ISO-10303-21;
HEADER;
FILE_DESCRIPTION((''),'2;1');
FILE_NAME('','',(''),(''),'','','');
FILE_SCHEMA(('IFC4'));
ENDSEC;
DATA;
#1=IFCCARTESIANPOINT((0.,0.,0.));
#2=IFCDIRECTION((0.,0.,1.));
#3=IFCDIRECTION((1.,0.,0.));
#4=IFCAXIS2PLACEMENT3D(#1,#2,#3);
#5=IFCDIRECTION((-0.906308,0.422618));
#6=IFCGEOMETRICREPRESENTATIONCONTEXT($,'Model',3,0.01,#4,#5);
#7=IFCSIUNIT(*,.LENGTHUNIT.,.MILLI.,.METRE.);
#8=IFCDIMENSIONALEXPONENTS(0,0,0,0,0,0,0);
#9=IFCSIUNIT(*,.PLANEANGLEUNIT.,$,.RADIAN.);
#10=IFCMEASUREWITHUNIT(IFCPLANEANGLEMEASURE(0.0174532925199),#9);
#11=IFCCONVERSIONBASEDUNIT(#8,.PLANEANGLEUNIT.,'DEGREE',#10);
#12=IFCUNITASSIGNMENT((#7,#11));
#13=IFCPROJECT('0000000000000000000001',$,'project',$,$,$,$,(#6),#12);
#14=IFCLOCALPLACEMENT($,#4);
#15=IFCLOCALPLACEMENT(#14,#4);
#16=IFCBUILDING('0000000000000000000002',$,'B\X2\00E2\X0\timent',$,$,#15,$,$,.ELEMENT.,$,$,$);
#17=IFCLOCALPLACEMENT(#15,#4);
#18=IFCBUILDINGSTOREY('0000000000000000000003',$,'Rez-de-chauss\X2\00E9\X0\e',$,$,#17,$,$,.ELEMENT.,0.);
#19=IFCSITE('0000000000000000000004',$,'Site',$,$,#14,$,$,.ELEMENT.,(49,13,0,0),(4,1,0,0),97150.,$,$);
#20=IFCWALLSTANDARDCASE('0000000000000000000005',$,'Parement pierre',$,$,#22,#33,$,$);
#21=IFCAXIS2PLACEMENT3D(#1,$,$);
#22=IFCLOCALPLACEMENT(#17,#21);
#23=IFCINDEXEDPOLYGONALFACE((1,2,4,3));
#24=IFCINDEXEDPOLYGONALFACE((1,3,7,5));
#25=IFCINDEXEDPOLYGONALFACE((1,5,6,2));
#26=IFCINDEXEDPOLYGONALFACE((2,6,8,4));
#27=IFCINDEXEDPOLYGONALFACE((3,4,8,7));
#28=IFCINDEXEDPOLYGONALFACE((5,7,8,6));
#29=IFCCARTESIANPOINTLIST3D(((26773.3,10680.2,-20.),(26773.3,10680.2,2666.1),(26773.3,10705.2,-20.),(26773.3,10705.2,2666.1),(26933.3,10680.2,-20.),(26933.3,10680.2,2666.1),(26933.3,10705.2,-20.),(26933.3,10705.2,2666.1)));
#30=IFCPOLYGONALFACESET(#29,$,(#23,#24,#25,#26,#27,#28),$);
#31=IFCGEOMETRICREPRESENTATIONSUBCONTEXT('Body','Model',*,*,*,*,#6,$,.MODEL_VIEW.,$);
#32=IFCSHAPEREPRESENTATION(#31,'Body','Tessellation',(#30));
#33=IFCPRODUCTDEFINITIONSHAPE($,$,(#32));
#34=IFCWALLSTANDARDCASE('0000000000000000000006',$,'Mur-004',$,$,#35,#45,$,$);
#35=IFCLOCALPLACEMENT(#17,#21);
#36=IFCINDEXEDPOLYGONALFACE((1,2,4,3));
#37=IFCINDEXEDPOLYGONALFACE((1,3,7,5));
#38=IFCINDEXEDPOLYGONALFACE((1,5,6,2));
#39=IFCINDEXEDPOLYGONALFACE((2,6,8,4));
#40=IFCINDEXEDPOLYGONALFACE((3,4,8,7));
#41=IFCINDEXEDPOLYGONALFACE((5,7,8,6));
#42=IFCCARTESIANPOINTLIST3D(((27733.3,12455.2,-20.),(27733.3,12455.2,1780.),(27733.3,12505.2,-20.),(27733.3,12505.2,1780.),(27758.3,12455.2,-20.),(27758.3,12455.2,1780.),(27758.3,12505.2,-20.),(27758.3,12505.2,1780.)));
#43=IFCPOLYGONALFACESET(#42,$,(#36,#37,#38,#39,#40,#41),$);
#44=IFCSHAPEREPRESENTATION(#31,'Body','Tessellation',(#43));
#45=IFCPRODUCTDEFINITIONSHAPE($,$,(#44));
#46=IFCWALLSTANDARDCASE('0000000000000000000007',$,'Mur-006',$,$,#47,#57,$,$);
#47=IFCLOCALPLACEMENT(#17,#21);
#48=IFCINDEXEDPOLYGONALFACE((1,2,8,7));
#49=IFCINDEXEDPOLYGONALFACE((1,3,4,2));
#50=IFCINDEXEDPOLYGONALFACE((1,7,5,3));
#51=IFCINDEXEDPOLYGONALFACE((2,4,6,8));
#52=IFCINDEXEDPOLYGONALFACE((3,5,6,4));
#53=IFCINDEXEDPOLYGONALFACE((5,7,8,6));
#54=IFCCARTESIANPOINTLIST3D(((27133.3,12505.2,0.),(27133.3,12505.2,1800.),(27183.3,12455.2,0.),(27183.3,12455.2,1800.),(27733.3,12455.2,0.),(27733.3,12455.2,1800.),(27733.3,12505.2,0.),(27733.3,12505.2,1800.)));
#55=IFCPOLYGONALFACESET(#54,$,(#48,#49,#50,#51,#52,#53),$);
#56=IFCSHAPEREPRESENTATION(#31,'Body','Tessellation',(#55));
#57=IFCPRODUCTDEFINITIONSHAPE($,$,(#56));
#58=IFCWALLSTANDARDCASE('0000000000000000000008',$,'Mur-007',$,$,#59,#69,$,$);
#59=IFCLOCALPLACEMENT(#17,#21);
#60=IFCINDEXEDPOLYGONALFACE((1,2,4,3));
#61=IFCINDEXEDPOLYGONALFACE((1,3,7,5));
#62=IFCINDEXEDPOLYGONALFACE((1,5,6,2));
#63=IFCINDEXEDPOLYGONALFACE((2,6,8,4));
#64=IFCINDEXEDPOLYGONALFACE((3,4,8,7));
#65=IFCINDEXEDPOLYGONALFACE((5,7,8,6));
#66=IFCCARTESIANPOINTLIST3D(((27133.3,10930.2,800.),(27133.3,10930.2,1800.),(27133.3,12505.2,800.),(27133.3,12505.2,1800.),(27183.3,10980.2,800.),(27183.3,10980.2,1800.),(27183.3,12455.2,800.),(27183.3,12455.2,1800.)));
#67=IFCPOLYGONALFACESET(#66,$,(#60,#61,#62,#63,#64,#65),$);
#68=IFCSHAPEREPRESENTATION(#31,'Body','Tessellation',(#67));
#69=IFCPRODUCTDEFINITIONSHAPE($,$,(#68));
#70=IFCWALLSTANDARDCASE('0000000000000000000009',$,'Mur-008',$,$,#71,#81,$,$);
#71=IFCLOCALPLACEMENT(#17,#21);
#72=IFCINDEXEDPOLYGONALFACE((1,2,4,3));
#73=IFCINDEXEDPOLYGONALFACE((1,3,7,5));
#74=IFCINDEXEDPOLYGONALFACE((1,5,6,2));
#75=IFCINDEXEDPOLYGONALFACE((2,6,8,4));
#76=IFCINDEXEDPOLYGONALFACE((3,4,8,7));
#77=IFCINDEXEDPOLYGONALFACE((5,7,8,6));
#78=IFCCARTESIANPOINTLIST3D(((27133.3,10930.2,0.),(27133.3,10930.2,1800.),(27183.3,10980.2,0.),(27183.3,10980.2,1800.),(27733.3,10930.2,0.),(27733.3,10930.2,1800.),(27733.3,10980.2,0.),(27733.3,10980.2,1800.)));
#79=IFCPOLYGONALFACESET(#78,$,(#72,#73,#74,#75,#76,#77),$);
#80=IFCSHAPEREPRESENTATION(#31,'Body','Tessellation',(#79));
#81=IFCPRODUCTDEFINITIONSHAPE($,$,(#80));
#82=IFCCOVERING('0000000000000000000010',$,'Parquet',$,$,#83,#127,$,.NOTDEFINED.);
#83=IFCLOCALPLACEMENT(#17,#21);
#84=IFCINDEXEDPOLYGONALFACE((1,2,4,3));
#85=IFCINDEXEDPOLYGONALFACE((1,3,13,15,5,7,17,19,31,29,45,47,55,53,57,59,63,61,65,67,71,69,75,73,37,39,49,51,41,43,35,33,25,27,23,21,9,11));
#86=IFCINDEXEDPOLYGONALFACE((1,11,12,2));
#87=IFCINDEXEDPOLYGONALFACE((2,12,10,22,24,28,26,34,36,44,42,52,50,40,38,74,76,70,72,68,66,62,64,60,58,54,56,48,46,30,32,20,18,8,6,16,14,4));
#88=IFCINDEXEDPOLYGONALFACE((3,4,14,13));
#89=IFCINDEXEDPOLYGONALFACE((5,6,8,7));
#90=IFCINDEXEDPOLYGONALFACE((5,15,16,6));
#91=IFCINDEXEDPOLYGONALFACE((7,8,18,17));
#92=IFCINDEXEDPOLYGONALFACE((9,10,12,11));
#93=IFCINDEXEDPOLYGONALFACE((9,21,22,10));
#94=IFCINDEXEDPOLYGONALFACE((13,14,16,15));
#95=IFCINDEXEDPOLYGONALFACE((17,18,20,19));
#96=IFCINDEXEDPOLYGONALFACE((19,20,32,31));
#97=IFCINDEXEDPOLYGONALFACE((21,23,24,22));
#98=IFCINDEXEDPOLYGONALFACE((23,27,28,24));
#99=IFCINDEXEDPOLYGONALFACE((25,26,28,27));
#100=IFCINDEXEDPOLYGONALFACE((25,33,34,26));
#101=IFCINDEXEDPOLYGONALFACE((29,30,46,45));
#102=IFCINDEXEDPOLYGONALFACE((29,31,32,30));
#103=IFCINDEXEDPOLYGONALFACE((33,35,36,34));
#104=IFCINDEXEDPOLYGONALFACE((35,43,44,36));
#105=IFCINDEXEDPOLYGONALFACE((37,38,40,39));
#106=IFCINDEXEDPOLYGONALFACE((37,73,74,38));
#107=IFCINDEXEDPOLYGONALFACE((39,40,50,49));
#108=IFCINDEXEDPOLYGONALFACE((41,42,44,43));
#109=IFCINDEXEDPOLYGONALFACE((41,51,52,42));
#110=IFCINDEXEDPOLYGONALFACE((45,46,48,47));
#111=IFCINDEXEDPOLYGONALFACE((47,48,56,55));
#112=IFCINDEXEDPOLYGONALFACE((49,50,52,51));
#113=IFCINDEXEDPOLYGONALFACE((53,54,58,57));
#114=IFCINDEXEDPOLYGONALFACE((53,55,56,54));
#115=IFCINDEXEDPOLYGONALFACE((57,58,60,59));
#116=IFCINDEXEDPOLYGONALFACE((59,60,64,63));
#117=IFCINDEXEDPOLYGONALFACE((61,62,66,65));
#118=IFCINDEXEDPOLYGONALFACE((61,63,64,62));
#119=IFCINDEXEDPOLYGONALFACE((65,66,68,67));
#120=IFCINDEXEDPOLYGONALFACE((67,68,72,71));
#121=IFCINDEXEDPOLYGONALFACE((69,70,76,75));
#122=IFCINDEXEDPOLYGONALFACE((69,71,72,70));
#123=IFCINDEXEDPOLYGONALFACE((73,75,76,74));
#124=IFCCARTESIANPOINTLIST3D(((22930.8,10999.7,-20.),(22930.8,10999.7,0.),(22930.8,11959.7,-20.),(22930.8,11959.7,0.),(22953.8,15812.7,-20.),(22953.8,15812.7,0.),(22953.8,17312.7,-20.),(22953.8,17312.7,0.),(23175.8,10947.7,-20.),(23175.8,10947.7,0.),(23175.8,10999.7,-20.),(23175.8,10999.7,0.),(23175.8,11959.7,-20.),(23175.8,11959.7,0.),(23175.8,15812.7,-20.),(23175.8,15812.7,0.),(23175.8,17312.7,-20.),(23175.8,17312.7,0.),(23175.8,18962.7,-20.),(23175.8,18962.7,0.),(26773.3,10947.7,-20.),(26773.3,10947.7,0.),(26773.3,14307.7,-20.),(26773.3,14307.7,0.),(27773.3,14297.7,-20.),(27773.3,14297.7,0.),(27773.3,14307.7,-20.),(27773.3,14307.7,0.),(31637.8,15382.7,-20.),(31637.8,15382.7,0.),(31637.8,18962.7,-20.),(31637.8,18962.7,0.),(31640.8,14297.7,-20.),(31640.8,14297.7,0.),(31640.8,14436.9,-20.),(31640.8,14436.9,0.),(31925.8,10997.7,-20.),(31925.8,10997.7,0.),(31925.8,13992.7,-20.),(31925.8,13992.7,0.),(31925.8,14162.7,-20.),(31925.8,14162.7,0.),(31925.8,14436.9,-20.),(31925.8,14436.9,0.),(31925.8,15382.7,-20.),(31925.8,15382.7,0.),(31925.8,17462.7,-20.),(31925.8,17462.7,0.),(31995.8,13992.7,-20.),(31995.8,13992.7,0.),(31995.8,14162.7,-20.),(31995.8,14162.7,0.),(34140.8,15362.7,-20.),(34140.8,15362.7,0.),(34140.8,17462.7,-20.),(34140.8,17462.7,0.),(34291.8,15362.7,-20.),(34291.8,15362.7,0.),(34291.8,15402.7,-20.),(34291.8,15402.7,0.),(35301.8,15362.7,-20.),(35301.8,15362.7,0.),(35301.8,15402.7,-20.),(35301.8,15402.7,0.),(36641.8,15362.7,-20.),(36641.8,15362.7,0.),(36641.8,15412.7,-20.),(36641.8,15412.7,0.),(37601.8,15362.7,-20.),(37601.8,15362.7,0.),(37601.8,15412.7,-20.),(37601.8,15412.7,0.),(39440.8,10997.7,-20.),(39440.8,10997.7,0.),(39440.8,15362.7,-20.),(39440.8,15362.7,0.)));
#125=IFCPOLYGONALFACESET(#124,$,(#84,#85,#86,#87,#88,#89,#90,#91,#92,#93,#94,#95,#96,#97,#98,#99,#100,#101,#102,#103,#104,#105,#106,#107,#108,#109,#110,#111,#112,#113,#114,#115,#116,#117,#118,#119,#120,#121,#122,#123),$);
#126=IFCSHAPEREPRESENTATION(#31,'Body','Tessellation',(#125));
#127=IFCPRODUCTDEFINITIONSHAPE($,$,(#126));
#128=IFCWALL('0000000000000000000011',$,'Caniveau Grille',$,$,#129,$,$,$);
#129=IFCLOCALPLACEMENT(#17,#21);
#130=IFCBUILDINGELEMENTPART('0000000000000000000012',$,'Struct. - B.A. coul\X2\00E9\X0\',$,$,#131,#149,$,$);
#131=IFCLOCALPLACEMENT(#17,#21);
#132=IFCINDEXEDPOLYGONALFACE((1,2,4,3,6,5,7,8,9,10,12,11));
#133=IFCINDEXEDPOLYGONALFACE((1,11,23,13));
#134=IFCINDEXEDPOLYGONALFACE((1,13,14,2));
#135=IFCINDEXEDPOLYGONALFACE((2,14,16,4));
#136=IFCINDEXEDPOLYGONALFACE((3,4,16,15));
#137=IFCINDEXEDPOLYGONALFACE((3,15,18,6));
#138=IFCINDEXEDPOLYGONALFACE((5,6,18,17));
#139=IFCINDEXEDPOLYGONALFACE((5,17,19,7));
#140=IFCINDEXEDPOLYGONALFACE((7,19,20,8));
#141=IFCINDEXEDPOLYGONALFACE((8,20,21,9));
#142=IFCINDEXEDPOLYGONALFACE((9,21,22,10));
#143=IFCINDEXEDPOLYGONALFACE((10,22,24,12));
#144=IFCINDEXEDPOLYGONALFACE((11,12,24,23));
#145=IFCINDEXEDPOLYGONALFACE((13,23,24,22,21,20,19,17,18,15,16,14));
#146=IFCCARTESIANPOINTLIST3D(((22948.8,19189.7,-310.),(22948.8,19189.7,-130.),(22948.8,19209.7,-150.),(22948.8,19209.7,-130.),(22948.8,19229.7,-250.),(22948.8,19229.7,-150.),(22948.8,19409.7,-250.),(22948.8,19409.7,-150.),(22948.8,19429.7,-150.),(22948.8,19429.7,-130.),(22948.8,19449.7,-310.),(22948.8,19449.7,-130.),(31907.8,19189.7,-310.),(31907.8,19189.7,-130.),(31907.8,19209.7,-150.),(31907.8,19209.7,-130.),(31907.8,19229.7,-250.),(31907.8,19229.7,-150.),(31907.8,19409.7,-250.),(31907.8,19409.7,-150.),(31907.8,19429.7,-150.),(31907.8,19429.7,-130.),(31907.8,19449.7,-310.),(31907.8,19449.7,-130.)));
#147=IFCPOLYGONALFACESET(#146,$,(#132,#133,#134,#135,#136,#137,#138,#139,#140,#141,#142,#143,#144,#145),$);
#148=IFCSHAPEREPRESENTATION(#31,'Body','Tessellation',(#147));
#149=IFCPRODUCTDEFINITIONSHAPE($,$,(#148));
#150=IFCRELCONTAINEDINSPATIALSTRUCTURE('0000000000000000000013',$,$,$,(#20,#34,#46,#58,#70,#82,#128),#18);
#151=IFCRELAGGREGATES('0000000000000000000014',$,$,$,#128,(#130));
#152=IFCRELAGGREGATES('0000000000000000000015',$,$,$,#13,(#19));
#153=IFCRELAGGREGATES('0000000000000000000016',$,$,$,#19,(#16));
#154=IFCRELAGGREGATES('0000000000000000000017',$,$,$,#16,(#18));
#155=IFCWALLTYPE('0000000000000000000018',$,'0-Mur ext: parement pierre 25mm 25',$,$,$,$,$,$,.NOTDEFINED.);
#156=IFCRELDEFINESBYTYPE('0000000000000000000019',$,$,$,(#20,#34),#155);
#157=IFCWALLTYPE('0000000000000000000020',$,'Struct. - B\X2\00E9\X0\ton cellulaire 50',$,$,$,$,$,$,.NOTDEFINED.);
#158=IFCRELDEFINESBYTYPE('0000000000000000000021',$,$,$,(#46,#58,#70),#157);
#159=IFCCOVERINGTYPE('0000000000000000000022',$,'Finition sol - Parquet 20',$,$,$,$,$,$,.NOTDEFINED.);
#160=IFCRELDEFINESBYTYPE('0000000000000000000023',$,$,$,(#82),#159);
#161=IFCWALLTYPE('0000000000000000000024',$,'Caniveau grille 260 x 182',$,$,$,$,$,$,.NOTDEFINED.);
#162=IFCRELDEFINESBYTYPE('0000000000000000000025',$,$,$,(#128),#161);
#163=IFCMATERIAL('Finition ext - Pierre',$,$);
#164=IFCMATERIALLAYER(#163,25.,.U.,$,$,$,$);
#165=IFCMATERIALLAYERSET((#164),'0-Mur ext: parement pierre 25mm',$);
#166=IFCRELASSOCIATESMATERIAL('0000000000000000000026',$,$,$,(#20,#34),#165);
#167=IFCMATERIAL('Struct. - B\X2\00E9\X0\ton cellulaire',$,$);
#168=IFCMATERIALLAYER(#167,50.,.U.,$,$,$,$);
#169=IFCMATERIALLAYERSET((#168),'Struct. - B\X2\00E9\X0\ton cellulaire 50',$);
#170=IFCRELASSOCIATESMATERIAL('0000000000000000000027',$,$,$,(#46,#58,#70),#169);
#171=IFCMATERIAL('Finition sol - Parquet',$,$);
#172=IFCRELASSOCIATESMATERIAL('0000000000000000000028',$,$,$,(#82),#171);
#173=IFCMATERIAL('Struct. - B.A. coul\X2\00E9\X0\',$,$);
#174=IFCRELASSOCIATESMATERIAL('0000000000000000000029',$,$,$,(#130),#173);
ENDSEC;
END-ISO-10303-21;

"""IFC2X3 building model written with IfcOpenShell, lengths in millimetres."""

from ifc_helpers import new_model, entity, si_unit, converted_unit, direction, frame, origin_with_axes, place, context, subcontext, project, spatial, polyline, outline, extrude, material, layer, layer_set, layer_usage, type_object, element, aggregate, save


model = new_model("IFC2X3")

# Units and contexts
model_context = context("Model", 3, precision=0.01, world=origin_with_axes(), true_north=direction((-0.906308, 0.422618)))
body_context = subcontext(model_context, "Body", "Model", "MODEL_VIEW")
ifc_project = project(units=[si_unit("LENGTHUNIT", "METRE", prefix="MILLI"), converted_unit("PLANEANGLEUNIT", "DEGREE", entity("IfcPlaneAngleMeasure", 0.0174532925199), si_unit("PLANEANGLEUNIT", "RADIAN"), dimensions=[0, 0, 0, 0, 0, 0, 0])], contexts=[model_context])

# Site, building, storey
site_placement = place(None, origin_with_axes())
site = spatial("IfcSite", under=ifc_project, at=site_placement, Name="Site", CompositionType="ELEMENT", RefLatitude=(49, 13, 0, 0), RefLongitude=(4, 1, 0, 0), RefElevation=97150.0)
building_placement = place(site_placement, origin_with_axes())
building = spatial("IfcBuilding", under=site, at=building_placement, Name="Bâtiment", CompositionType="ELEMENT")
storey_placement = place(building_placement, origin_with_axes())
storey = spatial("IfcBuildingStorey", under=building, at=storey_placement, Name="Rez-de-chaussée", CompositionType="ELEMENT", Elevation=0.0)

# Shared definitions
ifc_material_1 = material(Name="Struct. - B.A. coulé")

# Walls
ifc_material_2 = material(Name="Finition ext - Pierre")
ifc_layer_1 = layer(ifc_material_2, 25.0, ventilated="UNKNOWN")
ifc_layer_set_1 = layer_set([ifc_layer_1], Name="0-Mur ext: parement pierre 25mm")
ifc_layer_usage_1 = layer_usage(ifc_layer_set_1, "AXIS2", "POSITIVE", -25.0)
wall_type_1 = type_object("IfcWallType", Name="0-Mur ext: parement pierre 25mm 25", PredefinedType="NOTDEFINED")
wall_1_placement = place(storey_placement, frame((26933.3, 10680.2, -20.0), z_axis=(0.0, 0.0, 1.0), x_axis=(-1.0, 0.0, 0.0)))
element("IfcWallStandardCase", 1, at=wall_1_placement, inside=storey, type_object=wall_type_1, material=ifc_layer_usage_1, Name="Parement pierre", context=body_context, shape_type="SweptSolid", body=[
    extrude(outline(polyline([(0.0, -25.0), (160.0, -25.0), (160.0, 0.0), (0.0, 0.0), (0.0, -25.0)])), origin_with_axes(), (0.0, 0.0, 1.0), 2686.1),
])
ifc_layer_usage_2 = layer_usage(ifc_layer_set_1, "AXIS2", "POSITIVE", -25.0)
wall_2_placement = place(storey_placement, frame((27758.3, 12505.2, -20.0), z_axis=(0.0, 0.0, 1.0), x_axis=(0.0, -1.0, 0.0)))
element("IfcWallStandardCase", 2, at=wall_2_placement, inside=storey, type_object=wall_type_1, material=ifc_layer_usage_2, Name="Mur-004", context=body_context, shape_type="SweptSolid", body=[
    extrude(outline(polyline([(0.0, -25.0), (50.0, -25.0), (50.0, 0.0), (0.0, 0.0), (0.0, -25.0)])), origin_with_axes(), (0.0, 0.0, 1.0), 1800.0),
])
ifc_material_3 = material(Name="Struct. - Béton cellulaire")
ifc_layer_2 = layer(ifc_material_3, 50.0, ventilated="UNKNOWN")
ifc_layer_set_2 = layer_set([ifc_layer_2], Name="Struct. - Béton cellulaire 50")
ifc_layer_usage_3 = layer_usage(ifc_layer_set_2, "AXIS2", "POSITIVE", -50.0)
wall_type_2 = type_object("IfcWallType", Name="Struct. - Béton cellulaire 50", PredefinedType="NOTDEFINED")
wall_3_placement = place(storey_placement, frame((27733.3, 12455.2, 0.0), z_axis=(0.0, 0.0, 1.0), x_axis=(-1.0, 0.0, 0.0)))
element("IfcWallStandardCase", 3, at=wall_3_placement, inside=storey, type_object=wall_type_2, material=ifc_layer_usage_3, Name="Mur-006", context=body_context, shape_type="SweptSolid", body=[
    extrude(outline(polyline([(0.0, -50.0), (600.0, -50.0), (550.0, 0.0), (0.0, 0.0), (0.0, -50.0)])), origin_with_axes(), (0.0, 0.0, 1.0), 1800.0),
])
ifc_layer_usage_4 = layer_usage(ifc_layer_set_2, "AXIS2", "POSITIVE", 0.0)
wall_4_placement = place(storey_placement, frame((27133.3, 12455.2, 800.0), z_axis=(0.0, 0.0, 1.0), x_axis=(0.0, -1.0, 0.0)))
element("IfcWallStandardCase", 4, at=wall_4_placement, inside=storey, type_object=wall_type_2, material=ifc_layer_usage_4, Name="Mur-007", context=body_context, shape_type="SweptSolid", body=[
    extrude(outline(polyline([(-50.0, 0.0), (1525.0, 0.0), (1475.0, 50.0), (0.0, 50.0), (-50.0, 0.0)])), origin_with_axes(), (0.0, 0.0, 1.0), 1000.0),
])
ifc_layer_usage_5 = layer_usage(ifc_layer_set_2, "AXIS2", "POSITIVE", -50.0)
wall_5_placement = place(storey_placement, frame((27133.3, 10980.2, 0.0), z_axis=(0.0, 0.0, 1.0), x_axis=(1.0, 0.0, 0.0)))
element("IfcWallStandardCase", 5, at=wall_5_placement, inside=storey, type_object=wall_type_2, material=ifc_layer_usage_5, Name="Mur-008", context=body_context, shape_type="SweptSolid", body=[
    extrude(outline(polyline([(0.0, -50.0), (600.0, -50.0), (600.0, 0.0), (50.0, 0.0), (0.0, -50.0)])), origin_with_axes(), (0.0, 0.0, 1.0), 1800.0),
])

# Covering
ifc_material_4 = material(Name="Finition sol - Parquet")
covering_type = type_object("IfcCoveringType", Name="Finition sol - Parquet 20", PredefinedType="NOTDEFINED")
covering_placement = place(storey_placement, frame((22930.8, 11959.7, 0.0), z_axis=(0.0, 0.0, 1.0), x_axis=(1.0, 0.0, 0.0)))
element("IfcCovering", 6, at=covering_placement, inside=storey, type_object=covering_type, material=ifc_material_4, Name="Parquet", PredefinedType="NOTDEFINED", context=body_context, shape_type="SweptSolid", body=[
    extrude(outline(polyline([(0.0, 0.0), (0.0, -960.0), (245.0, -960.0), (245.0, -1012.0), (3842.5, -1012.0), (3842.5, 2348.0), (4842.5, 2348.0), (4842.5, 2338.0), (8710.0, 2338.0), (8710.0, 2477.3), (8995.0, 2477.3), (8995.0, 2203.0), (9064.9, 2203.0), (9064.9, 2033.0), (8995.0, 2033.0), (8995.0, -962.0), (16510.0, -962.0), (16510.0, 3403.0), (14671.0, 3403.0), (14671.0, 3453.0), (13711.0, 3453.0), (13711.0, 3403.0), (12371.0, 3403.0), (12371.0, 3443.0), (11361.0, 3443.0), (11361.0, 3403.0), (11210.0, 3403.0), (11210.0, 5503.0), (8995.0, 5503.0), (8995.0, 3423.0), (8707.0, 3423.0), (8707.0, 7003.0), (245.0, 7003.0), (245.0, 5353.0), (23.0, 5353.0), (23.0, 3853.0), (245.0, 3853.0), (245.0, 0.0), (0.0, 0.0)])), frame((0.0, 0.0, -20.0), z_axis=(0.0, 0.0, 1.0), x_axis=(1.0, 0.0, 0.0)), (0.0, 0.0, 1.0), 20.0),
])

# Wall, building element part
wall_type_3 = type_object("IfcWallType", Name="Caniveau grille 260 x 182", PredefinedType="NOTDEFINED")
wall_6_placement = place(storey_placement, frame((22948.8, 19319.7, -130.0), z_axis=(0.0, 0.0, 1.0), x_axis=(1.0, 0.0, 0.0)))
wall_6 = element("IfcWall", 7, at=wall_6_placement, inside=storey, type_object=wall_type_3, Name="Caniveau Grille")
building_element_part_1_placement = place(wall_6_placement, origin_with_axes())
building_element_part_1 = element("IfcBuildingElementPart", 8, at=building_element_part_1_placement, material=ifc_material_1, Name="Struct. - B.A. coulé", context=body_context, shape_type="SweptSolid", body=[
    extrude(outline(polyline([(-130.0, -180.0), (130.0, -180.0), (130.0, 0.0), (110.0, 0.0), (110.0, -20.0), (90.0, -20.0), (90.0, -120.0), (-90.0, -120.0), (-90.0, -20.0), (-110.0, -20.0), (-110.0, 0.0), (-130.0, 0.0), (-130.0, -180.0)])), frame((0.0, 0.0, 0.0), z_axis=(-1.0, 0.0, 0.0), x_axis=(0.0, -1.0, 0.0)), (0.0, 0.0, -1.0), 8959.0),
])
aggregate(wall_6, [building_element_part_1])

save(model, "model.ifc")
